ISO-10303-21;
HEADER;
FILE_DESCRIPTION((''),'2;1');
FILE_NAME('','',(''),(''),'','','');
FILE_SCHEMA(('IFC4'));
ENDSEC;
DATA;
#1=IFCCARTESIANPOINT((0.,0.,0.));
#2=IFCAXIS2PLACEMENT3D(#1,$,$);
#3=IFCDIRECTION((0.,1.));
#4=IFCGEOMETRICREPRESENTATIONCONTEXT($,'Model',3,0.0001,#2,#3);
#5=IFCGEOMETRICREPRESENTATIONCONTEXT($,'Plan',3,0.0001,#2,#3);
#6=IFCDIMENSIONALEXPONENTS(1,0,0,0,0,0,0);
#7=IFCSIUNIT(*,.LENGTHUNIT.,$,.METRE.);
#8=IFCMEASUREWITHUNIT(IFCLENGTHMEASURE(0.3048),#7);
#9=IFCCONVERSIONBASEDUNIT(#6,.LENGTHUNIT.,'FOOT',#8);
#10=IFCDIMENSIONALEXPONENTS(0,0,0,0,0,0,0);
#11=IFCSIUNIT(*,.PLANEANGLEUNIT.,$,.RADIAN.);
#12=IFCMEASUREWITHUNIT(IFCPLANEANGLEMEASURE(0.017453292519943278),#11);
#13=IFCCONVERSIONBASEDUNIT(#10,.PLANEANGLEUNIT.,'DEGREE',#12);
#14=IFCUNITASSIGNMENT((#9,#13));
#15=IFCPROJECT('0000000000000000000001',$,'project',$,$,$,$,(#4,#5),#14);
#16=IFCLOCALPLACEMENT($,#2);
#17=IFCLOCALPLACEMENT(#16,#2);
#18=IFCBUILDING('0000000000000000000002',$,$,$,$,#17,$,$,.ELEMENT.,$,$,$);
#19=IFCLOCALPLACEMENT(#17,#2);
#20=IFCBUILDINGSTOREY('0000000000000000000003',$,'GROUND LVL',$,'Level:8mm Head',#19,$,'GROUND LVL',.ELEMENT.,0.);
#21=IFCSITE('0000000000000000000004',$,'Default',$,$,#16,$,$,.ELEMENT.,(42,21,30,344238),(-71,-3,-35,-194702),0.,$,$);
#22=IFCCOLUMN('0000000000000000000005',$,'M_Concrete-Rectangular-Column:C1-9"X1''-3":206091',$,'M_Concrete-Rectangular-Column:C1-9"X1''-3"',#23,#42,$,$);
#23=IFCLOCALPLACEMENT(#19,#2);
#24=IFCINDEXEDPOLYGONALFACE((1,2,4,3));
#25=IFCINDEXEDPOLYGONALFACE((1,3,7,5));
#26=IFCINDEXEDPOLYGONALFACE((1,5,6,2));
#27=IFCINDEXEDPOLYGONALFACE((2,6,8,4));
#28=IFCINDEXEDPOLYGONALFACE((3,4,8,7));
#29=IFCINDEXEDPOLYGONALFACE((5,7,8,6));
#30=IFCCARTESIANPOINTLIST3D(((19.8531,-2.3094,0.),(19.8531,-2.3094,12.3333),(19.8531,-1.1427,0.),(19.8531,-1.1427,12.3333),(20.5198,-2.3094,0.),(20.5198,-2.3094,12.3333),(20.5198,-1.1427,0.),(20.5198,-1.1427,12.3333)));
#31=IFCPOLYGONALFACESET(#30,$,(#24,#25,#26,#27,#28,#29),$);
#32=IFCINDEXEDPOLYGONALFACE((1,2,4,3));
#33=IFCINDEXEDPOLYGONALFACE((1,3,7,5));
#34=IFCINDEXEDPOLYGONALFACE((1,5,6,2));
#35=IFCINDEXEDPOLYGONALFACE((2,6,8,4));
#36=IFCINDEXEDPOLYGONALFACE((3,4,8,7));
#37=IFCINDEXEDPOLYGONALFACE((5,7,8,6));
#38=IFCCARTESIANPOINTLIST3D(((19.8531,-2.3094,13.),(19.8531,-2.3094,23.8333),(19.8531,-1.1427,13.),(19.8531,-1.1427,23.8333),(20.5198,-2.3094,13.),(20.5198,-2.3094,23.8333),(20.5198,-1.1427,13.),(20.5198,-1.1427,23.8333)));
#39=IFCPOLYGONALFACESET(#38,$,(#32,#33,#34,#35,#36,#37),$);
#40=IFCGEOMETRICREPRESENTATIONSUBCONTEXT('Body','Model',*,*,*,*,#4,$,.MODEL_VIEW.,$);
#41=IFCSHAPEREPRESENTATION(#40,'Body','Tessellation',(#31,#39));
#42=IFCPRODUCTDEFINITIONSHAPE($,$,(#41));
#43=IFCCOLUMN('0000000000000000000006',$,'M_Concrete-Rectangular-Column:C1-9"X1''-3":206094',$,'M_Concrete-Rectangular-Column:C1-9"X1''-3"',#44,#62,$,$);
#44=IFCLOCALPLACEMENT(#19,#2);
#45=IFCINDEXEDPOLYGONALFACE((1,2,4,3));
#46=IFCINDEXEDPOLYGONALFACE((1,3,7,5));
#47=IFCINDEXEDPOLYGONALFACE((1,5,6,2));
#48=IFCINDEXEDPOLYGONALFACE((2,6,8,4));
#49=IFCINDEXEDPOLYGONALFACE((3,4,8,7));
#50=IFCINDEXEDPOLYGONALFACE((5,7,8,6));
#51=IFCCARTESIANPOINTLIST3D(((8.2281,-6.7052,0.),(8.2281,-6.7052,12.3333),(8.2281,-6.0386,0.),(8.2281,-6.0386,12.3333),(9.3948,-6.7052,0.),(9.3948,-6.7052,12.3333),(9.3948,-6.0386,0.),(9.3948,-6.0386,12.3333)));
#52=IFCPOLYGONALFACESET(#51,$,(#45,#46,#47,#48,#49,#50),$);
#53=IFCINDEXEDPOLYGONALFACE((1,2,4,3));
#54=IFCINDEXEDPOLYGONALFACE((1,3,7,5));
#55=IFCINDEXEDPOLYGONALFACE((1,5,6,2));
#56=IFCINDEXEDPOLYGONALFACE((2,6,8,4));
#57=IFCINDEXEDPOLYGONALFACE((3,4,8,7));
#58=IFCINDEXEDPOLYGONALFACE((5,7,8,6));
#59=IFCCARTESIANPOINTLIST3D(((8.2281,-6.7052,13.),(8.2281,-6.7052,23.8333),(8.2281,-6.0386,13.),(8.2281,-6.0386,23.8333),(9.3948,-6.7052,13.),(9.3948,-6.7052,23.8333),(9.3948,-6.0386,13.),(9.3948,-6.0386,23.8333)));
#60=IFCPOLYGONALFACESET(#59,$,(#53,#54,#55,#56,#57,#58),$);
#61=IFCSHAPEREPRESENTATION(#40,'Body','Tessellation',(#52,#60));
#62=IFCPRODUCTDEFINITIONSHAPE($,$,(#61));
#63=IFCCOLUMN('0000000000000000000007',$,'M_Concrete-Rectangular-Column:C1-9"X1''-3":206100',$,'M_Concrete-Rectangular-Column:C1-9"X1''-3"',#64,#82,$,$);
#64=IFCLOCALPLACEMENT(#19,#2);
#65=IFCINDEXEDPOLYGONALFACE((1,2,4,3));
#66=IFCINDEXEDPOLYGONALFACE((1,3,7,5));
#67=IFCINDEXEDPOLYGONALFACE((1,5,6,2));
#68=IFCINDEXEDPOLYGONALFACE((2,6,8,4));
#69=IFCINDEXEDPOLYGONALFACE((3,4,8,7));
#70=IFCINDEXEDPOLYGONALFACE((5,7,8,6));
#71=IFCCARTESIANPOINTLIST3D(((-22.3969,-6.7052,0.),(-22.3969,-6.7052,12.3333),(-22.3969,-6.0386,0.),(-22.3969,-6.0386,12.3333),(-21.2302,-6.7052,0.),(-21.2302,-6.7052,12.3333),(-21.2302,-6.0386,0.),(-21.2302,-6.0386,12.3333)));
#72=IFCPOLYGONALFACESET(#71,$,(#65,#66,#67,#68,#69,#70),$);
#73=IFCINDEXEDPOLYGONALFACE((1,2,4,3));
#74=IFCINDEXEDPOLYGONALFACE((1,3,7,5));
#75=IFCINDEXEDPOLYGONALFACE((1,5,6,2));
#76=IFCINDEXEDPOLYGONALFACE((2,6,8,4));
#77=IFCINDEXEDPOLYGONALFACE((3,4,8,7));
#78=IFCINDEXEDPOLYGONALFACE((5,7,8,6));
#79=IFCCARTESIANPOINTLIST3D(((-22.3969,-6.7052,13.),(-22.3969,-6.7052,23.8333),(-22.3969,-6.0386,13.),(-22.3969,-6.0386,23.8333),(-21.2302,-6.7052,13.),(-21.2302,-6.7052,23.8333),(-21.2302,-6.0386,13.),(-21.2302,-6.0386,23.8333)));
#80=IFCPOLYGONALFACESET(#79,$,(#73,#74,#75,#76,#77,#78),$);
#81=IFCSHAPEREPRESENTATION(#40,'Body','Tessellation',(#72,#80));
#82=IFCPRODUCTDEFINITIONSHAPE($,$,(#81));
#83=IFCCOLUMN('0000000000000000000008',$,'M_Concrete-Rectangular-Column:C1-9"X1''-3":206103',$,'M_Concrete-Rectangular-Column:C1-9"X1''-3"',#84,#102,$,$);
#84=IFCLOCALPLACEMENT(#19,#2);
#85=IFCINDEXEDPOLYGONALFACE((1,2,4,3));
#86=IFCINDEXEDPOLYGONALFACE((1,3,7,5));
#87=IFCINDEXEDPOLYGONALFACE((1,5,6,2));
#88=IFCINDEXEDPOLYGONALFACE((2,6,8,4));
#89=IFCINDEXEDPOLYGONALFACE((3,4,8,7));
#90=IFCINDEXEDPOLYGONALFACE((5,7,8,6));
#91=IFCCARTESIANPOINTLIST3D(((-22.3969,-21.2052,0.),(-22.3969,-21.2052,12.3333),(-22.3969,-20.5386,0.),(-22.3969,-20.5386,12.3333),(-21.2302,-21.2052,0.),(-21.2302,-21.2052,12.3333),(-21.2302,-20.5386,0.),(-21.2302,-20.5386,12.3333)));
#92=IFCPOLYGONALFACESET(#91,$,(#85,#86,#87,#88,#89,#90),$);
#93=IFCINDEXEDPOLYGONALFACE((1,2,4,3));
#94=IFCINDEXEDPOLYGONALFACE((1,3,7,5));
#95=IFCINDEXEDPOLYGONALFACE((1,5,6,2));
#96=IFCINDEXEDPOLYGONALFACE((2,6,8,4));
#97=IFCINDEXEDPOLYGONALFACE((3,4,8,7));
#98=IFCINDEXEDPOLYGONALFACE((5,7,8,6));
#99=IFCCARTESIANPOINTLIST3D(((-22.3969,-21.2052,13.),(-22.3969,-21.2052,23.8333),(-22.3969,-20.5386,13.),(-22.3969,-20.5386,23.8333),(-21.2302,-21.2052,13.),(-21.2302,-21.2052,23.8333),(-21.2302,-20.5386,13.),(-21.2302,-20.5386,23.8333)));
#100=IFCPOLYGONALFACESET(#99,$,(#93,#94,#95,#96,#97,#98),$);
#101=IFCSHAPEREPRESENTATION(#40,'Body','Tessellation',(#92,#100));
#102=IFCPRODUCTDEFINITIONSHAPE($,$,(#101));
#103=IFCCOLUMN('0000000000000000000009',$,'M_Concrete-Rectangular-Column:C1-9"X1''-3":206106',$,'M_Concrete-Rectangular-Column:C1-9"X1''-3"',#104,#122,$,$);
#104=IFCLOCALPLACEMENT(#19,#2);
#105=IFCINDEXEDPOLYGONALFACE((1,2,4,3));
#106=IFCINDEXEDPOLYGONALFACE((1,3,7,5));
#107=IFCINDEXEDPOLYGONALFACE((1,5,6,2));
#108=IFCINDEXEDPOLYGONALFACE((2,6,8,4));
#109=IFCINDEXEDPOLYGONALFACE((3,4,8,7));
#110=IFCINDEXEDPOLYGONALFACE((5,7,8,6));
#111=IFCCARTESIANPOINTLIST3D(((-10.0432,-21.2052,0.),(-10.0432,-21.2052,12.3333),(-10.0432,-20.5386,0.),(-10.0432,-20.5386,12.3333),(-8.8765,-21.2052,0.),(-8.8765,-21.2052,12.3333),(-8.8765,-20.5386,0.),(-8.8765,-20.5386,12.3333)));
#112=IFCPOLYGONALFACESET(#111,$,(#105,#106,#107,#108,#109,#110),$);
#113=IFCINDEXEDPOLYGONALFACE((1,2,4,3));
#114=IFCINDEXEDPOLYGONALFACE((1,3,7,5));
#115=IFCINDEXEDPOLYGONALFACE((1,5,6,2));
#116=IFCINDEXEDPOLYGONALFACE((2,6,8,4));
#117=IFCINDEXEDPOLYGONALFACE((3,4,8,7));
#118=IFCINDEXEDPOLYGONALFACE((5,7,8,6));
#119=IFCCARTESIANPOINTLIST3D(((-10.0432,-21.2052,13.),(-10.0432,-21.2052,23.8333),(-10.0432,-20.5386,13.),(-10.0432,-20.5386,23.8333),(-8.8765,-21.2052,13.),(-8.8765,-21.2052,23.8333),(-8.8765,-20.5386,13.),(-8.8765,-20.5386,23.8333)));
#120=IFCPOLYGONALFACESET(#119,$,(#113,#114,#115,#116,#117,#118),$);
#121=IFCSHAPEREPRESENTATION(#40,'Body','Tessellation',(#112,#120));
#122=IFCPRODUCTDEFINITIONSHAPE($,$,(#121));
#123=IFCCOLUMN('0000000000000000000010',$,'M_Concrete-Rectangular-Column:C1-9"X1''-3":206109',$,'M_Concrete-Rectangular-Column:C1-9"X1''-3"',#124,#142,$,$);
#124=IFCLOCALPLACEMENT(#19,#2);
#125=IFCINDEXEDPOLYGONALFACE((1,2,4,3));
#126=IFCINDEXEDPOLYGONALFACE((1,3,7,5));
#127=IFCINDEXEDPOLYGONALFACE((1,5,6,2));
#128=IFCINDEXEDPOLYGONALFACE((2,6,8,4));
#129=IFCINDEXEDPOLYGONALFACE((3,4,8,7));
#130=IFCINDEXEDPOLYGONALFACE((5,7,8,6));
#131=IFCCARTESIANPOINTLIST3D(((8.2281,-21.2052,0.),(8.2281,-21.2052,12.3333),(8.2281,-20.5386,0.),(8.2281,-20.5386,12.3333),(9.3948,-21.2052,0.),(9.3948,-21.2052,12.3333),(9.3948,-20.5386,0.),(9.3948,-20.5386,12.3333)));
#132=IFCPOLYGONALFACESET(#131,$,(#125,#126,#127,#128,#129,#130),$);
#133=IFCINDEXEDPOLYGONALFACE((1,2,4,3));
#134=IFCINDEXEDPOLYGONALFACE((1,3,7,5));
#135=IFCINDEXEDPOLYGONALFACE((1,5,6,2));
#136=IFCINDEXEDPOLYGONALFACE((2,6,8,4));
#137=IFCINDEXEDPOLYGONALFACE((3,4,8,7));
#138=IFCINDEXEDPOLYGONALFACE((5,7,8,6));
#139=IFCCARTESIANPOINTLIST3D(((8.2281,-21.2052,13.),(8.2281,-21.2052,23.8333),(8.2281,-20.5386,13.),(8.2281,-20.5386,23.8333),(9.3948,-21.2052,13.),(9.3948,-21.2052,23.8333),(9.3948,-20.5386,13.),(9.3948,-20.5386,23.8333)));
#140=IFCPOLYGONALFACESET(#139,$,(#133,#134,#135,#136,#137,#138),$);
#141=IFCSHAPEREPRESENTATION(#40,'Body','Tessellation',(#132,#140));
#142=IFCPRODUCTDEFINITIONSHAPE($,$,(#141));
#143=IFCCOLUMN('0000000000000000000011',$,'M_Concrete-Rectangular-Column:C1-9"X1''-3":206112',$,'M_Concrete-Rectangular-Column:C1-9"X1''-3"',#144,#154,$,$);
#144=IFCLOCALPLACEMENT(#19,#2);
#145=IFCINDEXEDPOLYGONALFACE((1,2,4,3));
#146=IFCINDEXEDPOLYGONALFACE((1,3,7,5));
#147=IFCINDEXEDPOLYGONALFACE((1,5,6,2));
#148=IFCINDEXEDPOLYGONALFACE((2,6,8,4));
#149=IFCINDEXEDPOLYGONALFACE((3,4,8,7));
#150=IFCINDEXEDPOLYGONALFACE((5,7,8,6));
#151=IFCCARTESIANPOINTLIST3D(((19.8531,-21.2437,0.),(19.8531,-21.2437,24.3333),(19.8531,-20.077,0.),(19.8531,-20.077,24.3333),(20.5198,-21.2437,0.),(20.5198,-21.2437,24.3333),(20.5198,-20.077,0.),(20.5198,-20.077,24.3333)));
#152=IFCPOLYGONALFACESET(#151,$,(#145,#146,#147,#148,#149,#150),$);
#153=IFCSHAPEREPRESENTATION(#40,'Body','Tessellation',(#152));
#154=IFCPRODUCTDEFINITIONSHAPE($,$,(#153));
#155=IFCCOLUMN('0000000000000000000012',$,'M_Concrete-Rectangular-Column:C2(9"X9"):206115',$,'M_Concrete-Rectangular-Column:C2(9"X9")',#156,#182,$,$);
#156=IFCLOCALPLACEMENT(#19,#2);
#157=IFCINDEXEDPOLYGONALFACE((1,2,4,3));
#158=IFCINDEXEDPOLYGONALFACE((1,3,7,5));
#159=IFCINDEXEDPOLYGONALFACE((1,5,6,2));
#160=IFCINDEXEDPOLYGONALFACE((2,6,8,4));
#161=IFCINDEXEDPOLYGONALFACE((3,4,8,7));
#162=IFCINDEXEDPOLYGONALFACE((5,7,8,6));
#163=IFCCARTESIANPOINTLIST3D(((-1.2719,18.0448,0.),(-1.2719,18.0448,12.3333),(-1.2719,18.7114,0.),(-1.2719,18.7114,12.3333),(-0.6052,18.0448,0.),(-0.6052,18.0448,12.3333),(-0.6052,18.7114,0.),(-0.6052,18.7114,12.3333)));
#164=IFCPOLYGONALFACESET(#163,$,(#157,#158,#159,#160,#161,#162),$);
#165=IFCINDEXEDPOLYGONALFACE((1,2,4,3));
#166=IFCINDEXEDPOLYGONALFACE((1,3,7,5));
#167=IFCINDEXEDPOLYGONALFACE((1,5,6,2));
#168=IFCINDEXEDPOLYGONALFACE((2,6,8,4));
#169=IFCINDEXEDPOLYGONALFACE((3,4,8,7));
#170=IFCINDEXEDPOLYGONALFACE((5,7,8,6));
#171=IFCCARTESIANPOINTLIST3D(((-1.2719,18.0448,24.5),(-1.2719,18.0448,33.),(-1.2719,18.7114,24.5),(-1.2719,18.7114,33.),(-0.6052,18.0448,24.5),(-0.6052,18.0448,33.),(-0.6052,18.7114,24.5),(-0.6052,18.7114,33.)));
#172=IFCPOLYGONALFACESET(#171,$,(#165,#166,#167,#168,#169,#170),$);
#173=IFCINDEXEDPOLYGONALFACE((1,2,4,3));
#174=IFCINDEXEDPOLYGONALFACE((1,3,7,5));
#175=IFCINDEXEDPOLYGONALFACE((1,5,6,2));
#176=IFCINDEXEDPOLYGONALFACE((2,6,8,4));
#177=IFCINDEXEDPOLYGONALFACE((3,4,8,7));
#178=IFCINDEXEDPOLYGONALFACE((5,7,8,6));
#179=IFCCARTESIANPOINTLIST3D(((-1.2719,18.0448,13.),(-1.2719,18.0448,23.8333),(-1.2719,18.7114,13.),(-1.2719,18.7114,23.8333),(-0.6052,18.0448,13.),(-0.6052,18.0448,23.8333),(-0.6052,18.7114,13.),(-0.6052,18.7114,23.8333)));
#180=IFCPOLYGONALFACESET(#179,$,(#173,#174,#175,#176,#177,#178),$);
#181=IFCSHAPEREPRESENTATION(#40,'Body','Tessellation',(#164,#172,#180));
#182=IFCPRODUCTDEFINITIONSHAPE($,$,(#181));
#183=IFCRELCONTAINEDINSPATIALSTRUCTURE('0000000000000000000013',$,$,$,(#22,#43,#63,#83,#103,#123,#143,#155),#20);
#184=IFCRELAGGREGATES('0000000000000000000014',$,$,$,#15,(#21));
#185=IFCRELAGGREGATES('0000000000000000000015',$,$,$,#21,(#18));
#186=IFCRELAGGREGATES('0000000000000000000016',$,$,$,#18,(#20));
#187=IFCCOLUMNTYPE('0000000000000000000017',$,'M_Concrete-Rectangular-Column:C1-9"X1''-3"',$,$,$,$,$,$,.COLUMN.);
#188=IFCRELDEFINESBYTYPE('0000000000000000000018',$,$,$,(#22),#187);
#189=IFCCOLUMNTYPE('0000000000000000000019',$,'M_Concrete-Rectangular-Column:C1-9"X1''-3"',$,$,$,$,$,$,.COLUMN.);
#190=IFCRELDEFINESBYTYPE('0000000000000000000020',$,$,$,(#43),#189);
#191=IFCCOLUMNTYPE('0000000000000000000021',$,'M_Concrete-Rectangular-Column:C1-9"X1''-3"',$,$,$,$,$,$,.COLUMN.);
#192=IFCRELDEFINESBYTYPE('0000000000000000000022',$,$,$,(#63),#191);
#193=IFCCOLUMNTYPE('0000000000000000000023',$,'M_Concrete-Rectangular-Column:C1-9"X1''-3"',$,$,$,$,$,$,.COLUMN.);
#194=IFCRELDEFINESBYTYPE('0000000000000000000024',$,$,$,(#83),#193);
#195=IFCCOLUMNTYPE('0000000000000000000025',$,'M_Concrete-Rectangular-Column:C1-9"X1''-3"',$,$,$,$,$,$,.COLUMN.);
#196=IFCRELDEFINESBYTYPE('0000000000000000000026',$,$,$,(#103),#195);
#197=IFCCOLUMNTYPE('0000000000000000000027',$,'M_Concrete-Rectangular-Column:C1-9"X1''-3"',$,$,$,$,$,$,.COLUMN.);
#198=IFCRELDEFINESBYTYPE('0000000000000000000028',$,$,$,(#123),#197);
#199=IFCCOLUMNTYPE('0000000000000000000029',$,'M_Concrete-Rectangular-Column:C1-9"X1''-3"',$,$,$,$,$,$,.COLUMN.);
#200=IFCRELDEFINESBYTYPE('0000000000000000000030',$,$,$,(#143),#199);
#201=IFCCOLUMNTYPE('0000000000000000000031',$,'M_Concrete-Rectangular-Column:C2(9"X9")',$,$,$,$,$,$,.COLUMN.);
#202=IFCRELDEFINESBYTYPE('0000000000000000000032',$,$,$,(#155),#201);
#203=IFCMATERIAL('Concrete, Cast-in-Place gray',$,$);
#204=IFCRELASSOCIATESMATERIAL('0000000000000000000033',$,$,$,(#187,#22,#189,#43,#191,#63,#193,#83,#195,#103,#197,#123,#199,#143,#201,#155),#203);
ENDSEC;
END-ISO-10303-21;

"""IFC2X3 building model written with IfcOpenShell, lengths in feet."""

from ifc_helpers import new_model, entity, si_unit, converted_unit, direction, frame, frame_2d, origin, origin_2d_with_axis, place, context, subcontext, project, spatial, rectangle, extrude, source, transform, mapped, material, type_object, type_shapes, element, save


model = new_model("IFC2X3")

# Units and contexts
model_context = context("Model", 3, precision=0.0001, world=origin(), true_north=direction((0.0, 1.0)))
plan_context = context("Plan", 3, precision=0.0001, world=origin(), true_north=direction((0.0, 1.0)))
body_context = subcontext(model_context, "Body", "Model", "MODEL_VIEW")
ifc_project = project(units=[converted_unit("LENGTHUNIT", "FOOT", entity("IfcLengthMeasure", 0.3048), si_unit("LENGTHUNIT", "METRE"), dimensions=[1, 0, 0, 0, 0, 0, 0]), converted_unit("PLANEANGLEUNIT", "DEGREE", entity("IfcPlaneAngleMeasure", 0.017453292519943278), si_unit("PLANEANGLEUNIT", "RADIAN"), dimensions=[0, 0, 0, 0, 0, 0, 0])], contexts=[model_context, plan_context])

# Site, building, storey
site_placement = place(None, origin())
site = spatial("IfcSite", under=ifc_project, at=site_placement, Name="Default", CompositionType="ELEMENT", RefLatitude=(42, 21, 30, 344238), RefLongitude=(-71, -3, -35, -194702), RefElevation=0.0)
building_placement = place(site_placement, origin())
building = spatial("IfcBuilding", under=site, at=building_placement, CompositionType="ELEMENT")
storey_placement = place(building_placement, origin())
storey = spatial("IfcBuildingStorey", under=building, at=storey_placement, Name="GROUND LVL", ObjectType="Level:8mm Head", LongName="GROUND LVL", CompositionType="ELEMENT", Elevation=0.0)

# Columns
ifc_material_1 = material(Name="Concrete, Cast-in-Place gray")
column_type_1 = type_object("IfcColumnType", Name="M_Concrete-Rectangular-Column:C1-9\"X1'-3\"", PredefinedType="COLUMN", material=ifc_material_1)
shared_shape_1 = source(origin(), body_context, "Body", "SweptSolid", [
    extrude(rectangle(XDim=12.3333, YDim=1.1667, at=frame_2d((1.5556, 0.0), x_axis=(1.0, 0.0))), frame((19.8531, -1.7261, 4.6111), z_axis=(1.0, 0.0, 0.0), x_axis=(0.0, 0.0, 1.0)), (0.0, 0.0, 1.0), 0.6667),
    extrude(rectangle(XDim=0.6667, YDim=1.1667, at=origin_2d_with_axis()), frame((20.1864, -1.7261, 13.0)), (0.0, 0.0, 1.0), 10.8333),
])
type_shapes(column_type_1, [shared_shape_1])
column_1_placement = place(storey_placement, origin())
element("IfcColumn", 1, at=column_1_placement, inside=storey, type_object=column_type_1, material=ifc_material_1, Name="M_Concrete-Rectangular-Column:C1-9\"X1'-3\":206091", ObjectType="M_Concrete-Rectangular-Column:C1-9\"X1'-3\"", context=body_context, shape_type="MappedRepresentation", body=[
    mapped(shared_shape_1, transform((0.0, 0.0, 0.0), scale=1.0)),
])
column_type_2 = type_object("IfcColumnType", Name="M_Concrete-Rectangular-Column:C1-9\"X1'-3\"", PredefinedType="COLUMN", material=ifc_material_1)
shared_shape_2 = source(origin(), body_context, "Body", "SweptSolid", [
    extrude(rectangle(XDim=0.6667, YDim=1.1667, at=frame_2d((0.0, 0.0), x_axis=(1.0, 0.0))), frame((8.8114, -6.3719, 0.0), z_axis=(0.0, 0.0, 1.0), x_axis=(0.0, 1.0, 0.0)), (0.0, 0.0, 1.0), 12.3333),
    extrude(rectangle(XDim=1.1667, YDim=0.6667, at=frame_2d((0.0417, 0.0), x_axis=(1.0, 0.0))), frame((8.7698, -6.3719, 13.0)), (0.0, 0.0, 1.0), 10.8333),
])
type_shapes(column_type_2, [shared_shape_2])
column_2_placement = place(storey_placement, origin())
element("IfcColumn", 2, at=column_2_placement, inside=storey, type_object=column_type_2, material=ifc_material_1, Name="M_Concrete-Rectangular-Column:C1-9\"X1'-3\":206094", ObjectType="M_Concrete-Rectangular-Column:C1-9\"X1'-3\"", context=body_context, shape_type="MappedRepresentation", body=[
    mapped(shared_shape_2, transform((0.0, 0.0, 0.0), scale=1.0)),
])
column_type_3 = type_object("IfcColumnType", Name="M_Concrete-Rectangular-Column:C1-9\"X1'-3\"", PredefinedType="COLUMN", material=ifc_material_1)
shared_shape_3 = source(origin(), body_context, "Body", "SweptSolid", [
    extrude(rectangle(XDim=0.6667, YDim=1.1667, at=frame_2d((0.0, 0.0), x_axis=(1.0, 0.0))), frame((-21.8136, -6.3719, 0.0), z_axis=(0.0, 0.0, 1.0), x_axis=(0.0, -1.0, 0.0)), (0.0, 0.0, 1.0), 12.3333),
    extrude(rectangle(XDim=0.6667, YDim=1.1667, at=frame_2d((0.0, 0.0), x_axis=(1.0, 0.0))), frame((-21.8136, -6.3719, 13.0), z_axis=(0.0, 0.0, 1.0), x_axis=(0.0, -1.0, 0.0)), (0.0, 0.0, 1.0), 10.8333),
])
type_shapes(column_type_3, [shared_shape_3])
column_3_placement = place(storey_placement, origin())
element("IfcColumn", 3, at=column_3_placement, inside=storey, type_object=column_type_3, material=ifc_material_1, Name="M_Concrete-Rectangular-Column:C1-9\"X1'-3\":206100", ObjectType="M_Concrete-Rectangular-Column:C1-9\"X1'-3\"", context=body_context, shape_type="MappedRepresentation", body=[
    mapped(shared_shape_3, transform((0.0, 0.0, 0.0), scale=1.0)),
])
column_type_4 = type_object("IfcColumnType", Name="M_Concrete-Rectangular-Column:C1-9\"X1'-3\"", PredefinedType="COLUMN", material=ifc_material_1)
shared_shape_4 = source(origin(), body_context, "Body", "SweptSolid", [
    extrude(rectangle(XDim=0.6667, YDim=1.1667, at=frame_2d((0.0, 0.0), x_axis=(1.0, 0.0))), frame((-21.8136, -20.8719, 0.0), z_axis=(0.0, 0.0, 1.0), x_axis=(0.0, -1.0, 0.0)), (0.0, 0.0, 1.0), 12.3333),
    extrude(rectangle(XDim=0.6667, YDim=1.1667, at=origin_2d_with_axis()), frame((-21.8136, -20.8719, 13.0), z_axis=(0.0, 0.0, 1.0), x_axis=(0.0, -1.0, 0.0)), (0.0, 0.0, 1.0), 10.8333),
])
type_shapes(column_type_4, [shared_shape_4])
column_4_placement = place(storey_placement, origin())
element("IfcColumn", 4, at=column_4_placement, inside=storey, type_object=column_type_4, material=ifc_material_1, Name="M_Concrete-Rectangular-Column:C1-9\"X1'-3\":206103", ObjectType="M_Concrete-Rectangular-Column:C1-9\"X1'-3\"", context=body_context, shape_type="MappedRepresentation", body=[
    mapped(shared_shape_4, transform((0.0, 0.0, 0.0), scale=1.0)),
])
column_type_5 = type_object("IfcColumnType", Name="M_Concrete-Rectangular-Column:C1-9\"X1'-3\"", PredefinedType="COLUMN", material=ifc_material_1)
shared_shape_5 = source(origin(), body_context, "Body", "SweptSolid", [
    extrude(rectangle(XDim=0.6667, YDim=1.1667, at=frame_2d((0.0, 0.0), x_axis=(1.0, 0.0))), frame((-9.4598, -20.8719, 0.0), z_axis=(0.0, 0.0, 1.0), x_axis=(0.0, -1.0, 0.0)), (0.0, 0.0, 1.0), 12.3333),
    extrude(rectangle(XDim=0.6667, YDim=1.1667, at=origin_2d_with_axis()), frame((-9.4598, -20.8719, 13.0), z_axis=(0.0, 0.0, 1.0), x_axis=(0.0, -1.0, 0.0)), (0.0, 0.0, 1.0), 10.8333),
])
type_shapes(column_type_5, [shared_shape_5])
column_5_placement = place(storey_placement, origin())
element("IfcColumn", 5, at=column_5_placement, inside=storey, type_object=column_type_5, material=ifc_material_1, Name="M_Concrete-Rectangular-Column:C1-9\"X1'-3\":206106", ObjectType="M_Concrete-Rectangular-Column:C1-9\"X1'-3\"", context=body_context, shape_type="MappedRepresentation", body=[
    mapped(shared_shape_5, transform((0.0, 0.0, 0.0), scale=1.0)),
])
column_type_6 = type_object("IfcColumnType", Name="M_Concrete-Rectangular-Column:C1-9\"X1'-3\"", PredefinedType="COLUMN", material=ifc_material_1)
shared_shape_6 = source(origin(), body_context, "Body", "SweptSolid", [
    extrude(rectangle(XDim=0.6667, YDim=1.1667, at=origin_2d_with_axis()), frame((8.8114, -20.8719, 0.0), z_axis=(0.0, 0.0, 1.0), x_axis=(0.0, -1.0, 0.0)), (0.0, 0.0, 1.0), 12.3333),
    extrude(rectangle(XDim=0.6667, YDim=1.1667, at=origin_2d_with_axis()), frame((8.8114, -20.8719, 13.0), z_axis=(0.0, 0.0, 1.0), x_axis=(0.0, -1.0, 0.0)), (0.0, 0.0, 1.0), 10.8333),
])
type_shapes(column_type_6, [shared_shape_6])
column_6_placement = place(storey_placement, origin())
element("IfcColumn", 6, at=column_6_placement, inside=storey, type_object=column_type_6, material=ifc_material_1, Name="M_Concrete-Rectangular-Column:C1-9\"X1'-3\":206109", ObjectType="M_Concrete-Rectangular-Column:C1-9\"X1'-3\"", context=body_context, shape_type="MappedRepresentation", body=[
    mapped(shared_shape_6, transform((0.0, 0.0, 0.0), scale=1.0)),
])
column_type_7 = type_object("IfcColumnType", Name="M_Concrete-Rectangular-Column:C1-9\"X1'-3\"", PredefinedType="COLUMN", material=ifc_material_1)
shared_shape_7 = source(origin(), body_context, "Body", "SweptSolid", [
    extrude(rectangle(XDim=0.6667, YDim=1.1667, at=origin_2d_with_axis()), frame((0.0, 0.0, 0.0), z_axis=(0.0, 0.0, 1.0), x_axis=(-1.0, 0.0, 0.0)), (0.0, 0.0, 1.0), 24.3333),
])
type_shapes(column_type_7, [shared_shape_7])
column_7_placement = place(storey_placement, frame((20.1864, -20.6604, 0.0), z_axis=(0.0, 0.0, 1.0), x_axis=(-1.0, 0.0, 0.0)))
element("IfcColumn", 7, at=column_7_placement, inside=storey, type_object=column_type_7, material=ifc_material_1, Name="M_Concrete-Rectangular-Column:C1-9\"X1'-3\":206112", ObjectType="M_Concrete-Rectangular-Column:C1-9\"X1'-3\"", context=body_context, shape_type="MappedRepresentation", body=[
    mapped(shared_shape_7, transform((0.0, 0.0, 0.0), scale=1.0)),
])
column_type_8 = type_object("IfcColumnType", Name="M_Concrete-Rectangular-Column:C2(9\"X9\")", PredefinedType="COLUMN", material=ifc_material_1)
shared_shape_8 = source(origin(), body_context, "Body", "SweptSolid", [
    extrude(rectangle(XDim=0.6667, YDim=0.6667, at=frame_2d((0.0, 0.0), x_axis=(1.0, 0.0))), frame((-0.9386, 18.3781, 0.0)), (0.0, 0.0, 1.0), 12.3333),
    extrude(rectangle(XDim=0.6667, YDim=0.6667, at=frame_2d((0.0, 0.0), x_axis=(1.0, 0.0))), frame((-0.9386, 18.3781, 24.5)), (0.0, 0.0, 1.0), 8.5),
    extrude(rectangle(XDim=0.6667, YDim=0.6667, at=frame_2d((0.0, 0.0), x_axis=(1.0, 0.0))), frame((-0.9386, 18.3781, 13.0)), (0.0, 0.0, 1.0), 10.8333),
])
type_shapes(column_type_8, [shared_shape_8])
column_8_placement = place(storey_placement, origin())
element("IfcColumn", 8, at=column_8_placement, inside=storey, type_object=column_type_8, material=ifc_material_1, Name="M_Concrete-Rectangular-Column:C2(9\"X9\"):206115", ObjectType="M_Concrete-Rectangular-Column:C2(9\"X9\")", context=body_context, shape_type="MappedRepresentation", body=[
    mapped(shared_shape_8, transform((0.0, 0.0, 0.0), scale=1.0)),
])

save(model, "model.ifc")
